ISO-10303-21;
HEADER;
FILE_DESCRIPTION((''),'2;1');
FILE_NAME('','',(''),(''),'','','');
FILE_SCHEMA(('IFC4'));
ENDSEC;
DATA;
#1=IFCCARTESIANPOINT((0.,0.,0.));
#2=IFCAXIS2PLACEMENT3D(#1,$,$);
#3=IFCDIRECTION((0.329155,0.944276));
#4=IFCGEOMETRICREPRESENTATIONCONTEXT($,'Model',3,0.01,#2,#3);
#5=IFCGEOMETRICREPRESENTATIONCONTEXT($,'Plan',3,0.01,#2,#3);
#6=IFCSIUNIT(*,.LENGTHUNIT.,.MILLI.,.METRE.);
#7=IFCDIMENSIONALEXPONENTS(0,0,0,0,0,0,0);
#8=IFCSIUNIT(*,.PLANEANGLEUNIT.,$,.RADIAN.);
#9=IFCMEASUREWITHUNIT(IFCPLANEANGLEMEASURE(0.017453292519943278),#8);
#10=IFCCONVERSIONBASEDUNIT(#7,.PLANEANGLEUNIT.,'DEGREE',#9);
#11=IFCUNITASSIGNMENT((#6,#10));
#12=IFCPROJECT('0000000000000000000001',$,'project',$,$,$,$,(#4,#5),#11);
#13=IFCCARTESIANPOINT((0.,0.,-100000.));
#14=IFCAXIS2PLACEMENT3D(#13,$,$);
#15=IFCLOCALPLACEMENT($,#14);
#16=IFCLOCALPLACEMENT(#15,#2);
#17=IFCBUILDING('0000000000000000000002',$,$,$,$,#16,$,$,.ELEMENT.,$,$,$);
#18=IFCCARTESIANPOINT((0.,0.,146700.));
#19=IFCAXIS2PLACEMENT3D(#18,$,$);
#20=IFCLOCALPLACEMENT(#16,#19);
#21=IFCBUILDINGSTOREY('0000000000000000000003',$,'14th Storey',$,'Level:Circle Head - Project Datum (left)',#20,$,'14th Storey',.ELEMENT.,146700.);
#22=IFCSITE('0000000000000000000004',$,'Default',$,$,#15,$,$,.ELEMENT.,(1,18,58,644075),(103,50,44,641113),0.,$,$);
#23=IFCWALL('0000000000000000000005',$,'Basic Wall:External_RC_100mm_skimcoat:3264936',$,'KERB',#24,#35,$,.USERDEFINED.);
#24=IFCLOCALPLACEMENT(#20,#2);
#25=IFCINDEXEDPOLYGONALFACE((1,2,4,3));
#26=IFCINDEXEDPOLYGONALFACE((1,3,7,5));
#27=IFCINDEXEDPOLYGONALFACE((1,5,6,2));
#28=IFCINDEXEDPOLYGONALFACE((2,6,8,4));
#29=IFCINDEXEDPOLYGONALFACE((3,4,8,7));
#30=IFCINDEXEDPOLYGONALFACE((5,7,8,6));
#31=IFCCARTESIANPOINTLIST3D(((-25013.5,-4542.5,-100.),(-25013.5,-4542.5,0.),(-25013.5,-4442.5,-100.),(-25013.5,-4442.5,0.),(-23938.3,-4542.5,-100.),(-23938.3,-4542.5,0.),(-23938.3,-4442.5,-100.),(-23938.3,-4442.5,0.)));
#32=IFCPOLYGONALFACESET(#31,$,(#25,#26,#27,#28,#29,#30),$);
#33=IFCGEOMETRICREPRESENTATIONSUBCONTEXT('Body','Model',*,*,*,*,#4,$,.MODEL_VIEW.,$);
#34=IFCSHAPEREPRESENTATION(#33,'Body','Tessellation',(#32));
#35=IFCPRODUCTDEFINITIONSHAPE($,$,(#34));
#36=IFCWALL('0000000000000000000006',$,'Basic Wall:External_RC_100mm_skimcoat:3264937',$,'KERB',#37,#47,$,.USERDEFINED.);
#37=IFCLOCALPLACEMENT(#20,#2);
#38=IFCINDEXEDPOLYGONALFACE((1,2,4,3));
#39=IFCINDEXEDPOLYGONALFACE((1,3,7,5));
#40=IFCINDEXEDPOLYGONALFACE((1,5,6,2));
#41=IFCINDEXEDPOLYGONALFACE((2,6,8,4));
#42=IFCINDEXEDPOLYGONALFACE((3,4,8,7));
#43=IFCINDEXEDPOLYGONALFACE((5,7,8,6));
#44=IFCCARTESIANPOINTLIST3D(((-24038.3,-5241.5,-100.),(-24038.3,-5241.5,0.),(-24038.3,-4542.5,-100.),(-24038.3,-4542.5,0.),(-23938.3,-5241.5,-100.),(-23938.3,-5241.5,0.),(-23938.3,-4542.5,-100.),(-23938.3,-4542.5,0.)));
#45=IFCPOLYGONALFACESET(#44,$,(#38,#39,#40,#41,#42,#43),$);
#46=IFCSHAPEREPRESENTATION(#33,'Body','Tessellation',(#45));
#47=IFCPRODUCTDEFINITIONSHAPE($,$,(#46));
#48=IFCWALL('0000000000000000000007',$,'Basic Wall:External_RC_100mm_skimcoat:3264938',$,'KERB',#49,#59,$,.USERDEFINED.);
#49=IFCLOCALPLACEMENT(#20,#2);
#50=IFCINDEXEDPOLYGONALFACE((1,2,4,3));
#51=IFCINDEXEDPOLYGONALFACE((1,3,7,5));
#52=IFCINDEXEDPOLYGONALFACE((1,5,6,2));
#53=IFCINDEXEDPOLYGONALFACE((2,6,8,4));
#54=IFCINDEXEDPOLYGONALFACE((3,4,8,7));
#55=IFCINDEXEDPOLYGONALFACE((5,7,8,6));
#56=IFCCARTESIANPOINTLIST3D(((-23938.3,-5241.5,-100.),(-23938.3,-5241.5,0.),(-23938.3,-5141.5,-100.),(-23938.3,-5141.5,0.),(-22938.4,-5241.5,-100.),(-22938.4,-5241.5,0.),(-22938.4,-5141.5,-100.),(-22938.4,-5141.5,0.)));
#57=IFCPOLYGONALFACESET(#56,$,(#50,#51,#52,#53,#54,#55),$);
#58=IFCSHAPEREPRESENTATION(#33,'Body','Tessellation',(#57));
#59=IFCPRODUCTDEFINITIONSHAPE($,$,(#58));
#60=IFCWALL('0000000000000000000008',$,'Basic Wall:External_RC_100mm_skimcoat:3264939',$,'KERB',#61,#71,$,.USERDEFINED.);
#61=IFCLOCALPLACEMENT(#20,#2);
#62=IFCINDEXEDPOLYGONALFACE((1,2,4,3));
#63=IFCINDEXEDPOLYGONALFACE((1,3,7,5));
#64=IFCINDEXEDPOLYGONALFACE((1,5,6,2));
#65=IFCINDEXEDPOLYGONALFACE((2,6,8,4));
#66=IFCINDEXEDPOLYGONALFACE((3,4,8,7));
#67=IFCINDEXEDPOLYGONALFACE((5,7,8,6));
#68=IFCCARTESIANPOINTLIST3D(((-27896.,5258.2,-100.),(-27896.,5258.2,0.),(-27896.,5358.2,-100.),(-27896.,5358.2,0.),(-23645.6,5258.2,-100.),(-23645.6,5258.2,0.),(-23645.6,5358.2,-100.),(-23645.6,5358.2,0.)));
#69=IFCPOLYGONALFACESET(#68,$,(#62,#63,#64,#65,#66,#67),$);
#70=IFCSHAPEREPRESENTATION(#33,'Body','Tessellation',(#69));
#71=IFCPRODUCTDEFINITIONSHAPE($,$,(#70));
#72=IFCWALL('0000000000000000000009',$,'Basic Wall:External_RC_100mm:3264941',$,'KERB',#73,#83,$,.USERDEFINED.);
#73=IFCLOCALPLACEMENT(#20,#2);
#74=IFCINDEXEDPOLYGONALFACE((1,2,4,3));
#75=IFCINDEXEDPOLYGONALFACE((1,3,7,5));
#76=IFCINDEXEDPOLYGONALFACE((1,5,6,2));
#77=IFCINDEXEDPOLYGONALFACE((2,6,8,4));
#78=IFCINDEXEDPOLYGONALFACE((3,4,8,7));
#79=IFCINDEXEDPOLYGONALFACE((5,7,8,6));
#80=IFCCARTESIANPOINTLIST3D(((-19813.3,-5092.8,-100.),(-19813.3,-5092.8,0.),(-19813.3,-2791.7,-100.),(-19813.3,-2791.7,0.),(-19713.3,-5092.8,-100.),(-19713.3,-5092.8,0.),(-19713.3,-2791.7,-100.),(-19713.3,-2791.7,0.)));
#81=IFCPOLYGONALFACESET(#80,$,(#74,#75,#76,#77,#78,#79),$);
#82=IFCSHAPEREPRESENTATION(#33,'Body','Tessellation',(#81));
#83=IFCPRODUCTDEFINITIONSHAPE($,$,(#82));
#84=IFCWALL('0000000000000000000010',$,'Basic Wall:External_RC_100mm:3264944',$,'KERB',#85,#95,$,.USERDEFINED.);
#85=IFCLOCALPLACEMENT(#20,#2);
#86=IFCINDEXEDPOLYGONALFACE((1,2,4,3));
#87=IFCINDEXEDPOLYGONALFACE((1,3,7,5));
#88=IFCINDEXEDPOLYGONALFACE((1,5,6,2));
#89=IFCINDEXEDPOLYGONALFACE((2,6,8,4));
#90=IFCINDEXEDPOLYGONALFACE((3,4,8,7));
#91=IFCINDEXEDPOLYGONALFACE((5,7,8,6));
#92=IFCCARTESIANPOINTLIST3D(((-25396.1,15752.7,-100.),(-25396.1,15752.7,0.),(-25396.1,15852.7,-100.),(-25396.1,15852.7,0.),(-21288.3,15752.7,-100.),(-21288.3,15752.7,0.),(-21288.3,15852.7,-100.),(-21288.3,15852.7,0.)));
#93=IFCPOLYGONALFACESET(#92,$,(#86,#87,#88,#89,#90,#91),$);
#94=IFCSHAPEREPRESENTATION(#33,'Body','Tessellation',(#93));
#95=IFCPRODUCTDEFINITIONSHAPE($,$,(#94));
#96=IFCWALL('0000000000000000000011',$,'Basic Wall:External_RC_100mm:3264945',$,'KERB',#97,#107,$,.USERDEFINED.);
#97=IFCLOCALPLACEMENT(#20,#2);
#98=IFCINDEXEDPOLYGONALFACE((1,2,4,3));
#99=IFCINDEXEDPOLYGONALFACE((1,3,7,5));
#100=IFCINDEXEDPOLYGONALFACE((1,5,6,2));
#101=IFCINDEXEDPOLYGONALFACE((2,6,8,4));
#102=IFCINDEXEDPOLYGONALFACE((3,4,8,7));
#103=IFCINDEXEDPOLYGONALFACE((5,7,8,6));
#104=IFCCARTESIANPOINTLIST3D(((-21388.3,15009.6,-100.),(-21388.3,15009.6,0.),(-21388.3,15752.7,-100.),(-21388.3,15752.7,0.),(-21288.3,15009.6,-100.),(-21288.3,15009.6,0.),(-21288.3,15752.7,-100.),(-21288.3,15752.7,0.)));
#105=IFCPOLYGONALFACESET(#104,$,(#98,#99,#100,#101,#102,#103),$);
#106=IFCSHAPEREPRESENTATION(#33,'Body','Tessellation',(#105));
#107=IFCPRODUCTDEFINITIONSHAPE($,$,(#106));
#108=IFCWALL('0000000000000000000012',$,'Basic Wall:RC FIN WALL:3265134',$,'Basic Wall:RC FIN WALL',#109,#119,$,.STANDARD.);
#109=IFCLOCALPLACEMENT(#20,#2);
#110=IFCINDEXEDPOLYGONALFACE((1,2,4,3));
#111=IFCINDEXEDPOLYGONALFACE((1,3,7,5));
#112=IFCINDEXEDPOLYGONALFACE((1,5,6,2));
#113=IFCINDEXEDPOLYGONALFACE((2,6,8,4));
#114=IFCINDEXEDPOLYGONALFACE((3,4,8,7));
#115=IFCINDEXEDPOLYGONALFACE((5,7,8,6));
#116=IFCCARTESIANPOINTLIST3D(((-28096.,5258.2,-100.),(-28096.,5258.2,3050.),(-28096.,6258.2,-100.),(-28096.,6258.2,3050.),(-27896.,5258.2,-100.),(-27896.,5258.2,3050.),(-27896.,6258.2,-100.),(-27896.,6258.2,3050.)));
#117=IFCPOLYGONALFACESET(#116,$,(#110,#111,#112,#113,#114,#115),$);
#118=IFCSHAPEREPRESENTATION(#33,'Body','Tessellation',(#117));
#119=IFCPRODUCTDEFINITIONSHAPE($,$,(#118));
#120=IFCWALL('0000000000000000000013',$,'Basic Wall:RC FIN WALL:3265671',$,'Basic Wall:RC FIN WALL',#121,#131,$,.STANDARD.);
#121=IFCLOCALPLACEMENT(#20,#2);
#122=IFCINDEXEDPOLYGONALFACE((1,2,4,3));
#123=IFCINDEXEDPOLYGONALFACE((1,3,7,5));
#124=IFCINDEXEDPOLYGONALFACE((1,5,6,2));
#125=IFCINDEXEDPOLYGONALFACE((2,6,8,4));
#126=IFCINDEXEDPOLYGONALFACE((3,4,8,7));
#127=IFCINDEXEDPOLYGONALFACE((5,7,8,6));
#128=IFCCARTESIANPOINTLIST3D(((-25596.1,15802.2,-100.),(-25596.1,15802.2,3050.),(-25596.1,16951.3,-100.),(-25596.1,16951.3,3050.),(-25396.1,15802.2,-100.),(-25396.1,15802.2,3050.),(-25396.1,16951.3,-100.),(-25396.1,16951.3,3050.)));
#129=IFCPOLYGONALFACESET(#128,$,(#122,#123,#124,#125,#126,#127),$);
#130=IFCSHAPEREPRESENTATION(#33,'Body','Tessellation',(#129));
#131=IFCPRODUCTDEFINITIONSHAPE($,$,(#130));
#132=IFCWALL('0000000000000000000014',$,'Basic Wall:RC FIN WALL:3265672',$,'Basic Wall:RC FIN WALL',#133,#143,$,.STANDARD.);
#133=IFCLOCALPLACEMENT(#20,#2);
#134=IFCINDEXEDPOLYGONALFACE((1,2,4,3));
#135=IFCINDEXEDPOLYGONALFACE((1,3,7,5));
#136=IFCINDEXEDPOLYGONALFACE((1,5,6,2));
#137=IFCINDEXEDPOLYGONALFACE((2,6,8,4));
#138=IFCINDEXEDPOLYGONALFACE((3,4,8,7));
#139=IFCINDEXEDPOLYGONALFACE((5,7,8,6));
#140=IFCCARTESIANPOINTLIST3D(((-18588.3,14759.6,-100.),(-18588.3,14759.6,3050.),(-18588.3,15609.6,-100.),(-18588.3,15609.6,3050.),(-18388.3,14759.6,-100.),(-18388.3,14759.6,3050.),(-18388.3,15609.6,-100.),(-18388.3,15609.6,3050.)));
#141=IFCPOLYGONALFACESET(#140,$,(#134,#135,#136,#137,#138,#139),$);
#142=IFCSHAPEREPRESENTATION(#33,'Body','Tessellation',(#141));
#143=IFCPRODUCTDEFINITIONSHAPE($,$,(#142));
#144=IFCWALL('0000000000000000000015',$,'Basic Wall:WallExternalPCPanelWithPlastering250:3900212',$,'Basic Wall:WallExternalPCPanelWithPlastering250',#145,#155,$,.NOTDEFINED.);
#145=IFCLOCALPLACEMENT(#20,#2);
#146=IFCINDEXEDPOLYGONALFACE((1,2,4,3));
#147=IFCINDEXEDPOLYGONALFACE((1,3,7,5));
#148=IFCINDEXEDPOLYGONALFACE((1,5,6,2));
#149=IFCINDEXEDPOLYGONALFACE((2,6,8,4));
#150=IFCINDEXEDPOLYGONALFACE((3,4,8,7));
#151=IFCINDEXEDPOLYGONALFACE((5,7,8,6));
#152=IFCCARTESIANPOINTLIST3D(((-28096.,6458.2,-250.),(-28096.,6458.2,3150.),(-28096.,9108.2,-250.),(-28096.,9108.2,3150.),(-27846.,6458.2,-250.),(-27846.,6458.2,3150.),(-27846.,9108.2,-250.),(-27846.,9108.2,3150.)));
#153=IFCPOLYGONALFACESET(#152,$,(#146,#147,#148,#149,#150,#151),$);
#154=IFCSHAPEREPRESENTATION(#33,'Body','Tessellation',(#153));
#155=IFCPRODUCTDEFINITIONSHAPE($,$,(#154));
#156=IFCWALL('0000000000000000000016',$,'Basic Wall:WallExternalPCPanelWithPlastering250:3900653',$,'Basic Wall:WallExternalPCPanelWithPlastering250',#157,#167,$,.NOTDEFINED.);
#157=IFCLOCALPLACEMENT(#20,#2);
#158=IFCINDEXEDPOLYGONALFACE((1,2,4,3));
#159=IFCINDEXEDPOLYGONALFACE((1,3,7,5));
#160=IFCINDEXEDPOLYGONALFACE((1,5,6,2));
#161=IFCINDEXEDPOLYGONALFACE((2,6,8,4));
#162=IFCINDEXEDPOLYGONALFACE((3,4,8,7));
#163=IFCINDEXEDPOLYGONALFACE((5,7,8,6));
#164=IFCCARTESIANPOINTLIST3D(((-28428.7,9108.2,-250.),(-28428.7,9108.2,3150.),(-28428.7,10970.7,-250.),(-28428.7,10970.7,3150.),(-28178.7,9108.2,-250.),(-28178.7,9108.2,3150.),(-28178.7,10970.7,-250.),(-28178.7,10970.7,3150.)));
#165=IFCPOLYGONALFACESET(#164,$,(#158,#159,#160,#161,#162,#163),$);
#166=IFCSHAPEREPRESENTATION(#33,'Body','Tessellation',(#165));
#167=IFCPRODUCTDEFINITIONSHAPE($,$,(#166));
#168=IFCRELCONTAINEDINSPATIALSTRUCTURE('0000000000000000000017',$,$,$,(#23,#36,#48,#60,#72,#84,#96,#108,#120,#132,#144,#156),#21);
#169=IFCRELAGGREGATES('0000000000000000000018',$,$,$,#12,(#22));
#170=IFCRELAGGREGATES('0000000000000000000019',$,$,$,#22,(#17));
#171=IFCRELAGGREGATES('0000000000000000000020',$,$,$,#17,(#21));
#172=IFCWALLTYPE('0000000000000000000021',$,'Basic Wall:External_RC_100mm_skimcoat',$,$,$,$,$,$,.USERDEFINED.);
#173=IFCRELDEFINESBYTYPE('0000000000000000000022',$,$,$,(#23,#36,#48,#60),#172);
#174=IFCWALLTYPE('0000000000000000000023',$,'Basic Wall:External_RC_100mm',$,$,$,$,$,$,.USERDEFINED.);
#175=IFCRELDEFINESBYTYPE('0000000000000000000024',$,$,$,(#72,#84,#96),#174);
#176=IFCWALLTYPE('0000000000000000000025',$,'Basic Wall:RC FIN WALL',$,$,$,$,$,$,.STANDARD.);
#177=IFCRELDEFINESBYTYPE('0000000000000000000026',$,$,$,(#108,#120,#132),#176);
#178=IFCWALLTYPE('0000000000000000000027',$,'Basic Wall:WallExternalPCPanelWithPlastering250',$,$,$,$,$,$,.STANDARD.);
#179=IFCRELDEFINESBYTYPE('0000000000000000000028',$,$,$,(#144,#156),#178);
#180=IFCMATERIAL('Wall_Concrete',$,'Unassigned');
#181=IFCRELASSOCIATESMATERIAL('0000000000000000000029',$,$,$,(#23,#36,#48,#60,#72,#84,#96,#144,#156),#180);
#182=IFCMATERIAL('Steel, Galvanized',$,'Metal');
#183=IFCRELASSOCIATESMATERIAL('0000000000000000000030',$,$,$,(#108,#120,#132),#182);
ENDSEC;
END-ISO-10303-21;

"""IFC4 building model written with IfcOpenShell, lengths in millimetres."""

from ifc_helpers import new_model, entity, si_unit, converted_unit, direction, frame, origin, place, context, subcontext, project, spatial, indexed_curve, outline, extrude, material, type_object, element, save


model = new_model("IFC4")

# Units and contexts
model_context = context("Model", 3, precision=0.01, world=origin(), true_north=direction((0.329155, 0.944276)))
plan_context = context("Plan", 3, precision=0.01, world=origin(), true_north=direction((0.329155, 0.944276)))
body_context = subcontext(model_context, "Body", "Model", "MODEL_VIEW")
ifc_project = project(units=[si_unit("LENGTHUNIT", "METRE", prefix="MILLI"), converted_unit("PLANEANGLEUNIT", "DEGREE", entity("IfcPlaneAngleMeasure", 0.017453292519943278), si_unit("PLANEANGLEUNIT", "RADIAN"), dimensions=[0, 0, 0, 0, 0, 0, 0])], contexts=[model_context, plan_context])

# Site, building, storey
site_placement = place(None, frame((0.0, 0.0, -100000.0)))
site = spatial("IfcSite", under=ifc_project, at=site_placement, Name="Default", CompositionType="ELEMENT", RefLatitude=(1, 18, 58, 644075), RefLongitude=(103, 50, 44, 641113), RefElevation=0.0)
building_placement = place(site_placement, origin())
building = spatial("IfcBuilding", under=site, at=building_placement, CompositionType="ELEMENT")
storey_placement = place(building_placement, frame((0.0, 0.0, 146700.0)))
storey = spatial("IfcBuildingStorey", under=building, at=storey_placement, Name="14th Storey", ObjectType="Level:Circle Head - Project Datum (left)", LongName="14th Storey", CompositionType="ELEMENT", Elevation=146700.0)

# Walls
ifc_material_1 = material(Name="Wall_Concrete", Category="Unassigned")
wall_type_1 = type_object("IfcWallType", Name="Basic Wall:External_RC_100mm_skimcoat", PredefinedType="USERDEFINED")
wall_1_placement = place(storey_placement, frame((-25013.5, -4492.5, -100.0)))
element("IfcWall", 1, at=wall_1_placement, inside=storey, type_object=wall_type_1, material=ifc_material_1, Name="Basic Wall:External_RC_100mm_skimcoat:3264936", ObjectType="KERB", PredefinedType="USERDEFINED", context=body_context, shape_type="SweptSolid", body=[
    extrude(outline(indexed_curve([(1075.2, 50.0), (0.0, 50.0), (0.0, -50.0), (1075.2, -50.0), (1075.2, 50.0)], self_intersect=False)), origin(), (0.0, 0.0, 1.0), 100.0),
])
wall_2_placement = place(storey_placement, frame((-23988.3, -4542.5, -100.0), z_axis=(0.0, 0.0, 1.0), x_axis=(0.0, -1.0, 0.0)))
element("IfcWall", 2, at=wall_2_placement, inside=storey, type_object=wall_type_1, material=ifc_material_1, Name="Basic Wall:External_RC_100mm_skimcoat:3264937", ObjectType="KERB", PredefinedType="USERDEFINED", context=body_context, shape_type="SweptSolid", body=[
    extrude(outline(indexed_curve([(699.0, 50.0), (0.0, 50.0), (0.0, -50.0), (699.0, -50.0), (699.0, 50.0)], self_intersect=False)), origin(), (0.0, 0.0, 1.0), 100.0),
])
wall_3_placement = place(storey_placement, frame((-23938.3, -5191.5, -100.0)))
element("IfcWall", 3, at=wall_3_placement, inside=storey, type_object=wall_type_1, material=ifc_material_1, Name="Basic Wall:External_RC_100mm_skimcoat:3264938", ObjectType="KERB", PredefinedType="USERDEFINED", context=body_context, shape_type="SweptSolid", body=[
    extrude(outline(indexed_curve([(1000.0, 50.0), (0.0, 50.0), (0.0, -50.0), (1000.0, -50.0), (1000.0, 50.0)], self_intersect=False)), origin(), (0.0, 0.0, 1.0), 100.0),
])
wall_4_placement = place(storey_placement, frame((-27896.0, 5308.2, -100.0)))
element("IfcWall", 4, at=wall_4_placement, inside=storey, type_object=wall_type_1, material=ifc_material_1, Name="Basic Wall:External_RC_100mm_skimcoat:3264939", ObjectType="KERB", PredefinedType="USERDEFINED", context=body_context, shape_type="SweptSolid", body=[
    extrude(outline(indexed_curve([(4250.4, 50.0), (0.0, 50.0), (0.0, -50.0), (4250.4, -50.0), (4250.4, 50.0)], self_intersect=False)), origin(), (0.0, 0.0, 1.0), 100.0),
])
wall_type_2 = type_object("IfcWallType", Name="Basic Wall:External_RC_100mm", PredefinedType="USERDEFINED")
wall_5_placement = place(storey_placement, frame((-19763.3, -5092.8, -100.0), z_axis=(0.0, 0.0, 1.0), x_axis=(0.0, 1.0, 0.0)))
element("IfcWall", 5, at=wall_5_placement, inside=storey, type_object=wall_type_2, material=ifc_material_1, Name="Basic Wall:External_RC_100mm:3264941", ObjectType="KERB", PredefinedType="USERDEFINED", context=body_context, shape_type="SweptSolid", body=[
    extrude(outline(indexed_curve([(2301.0, 50.0), (0.0, 50.0), (0.0, -50.0), (2301.0, -50.0), (2301.0, 50.0)], self_intersect=False)), origin(), (0.0, 0.0, 1.0), 100.0),
])
wall_6_placement = place(storey_placement, frame((-25396.1, 15802.7, -100.0)))
element("IfcWall", 6, at=wall_6_placement, inside=storey, type_object=wall_type_2, material=ifc_material_1, Name="Basic Wall:External_RC_100mm:3264944", ObjectType="KERB", PredefinedType="USERDEFINED", context=body_context, shape_type="SweptSolid", body=[
    extrude(outline(indexed_curve([(4107.8, 50.0), (0.0, 50.0), (0.0, -50.0), (4107.8, -50.0), (4107.8, 50.0)], self_intersect=False)), origin(), (0.0, 0.0, 1.0), 100.0),
])
wall_7_placement = place(storey_placement, frame((-21338.3, 15752.7, -100.0), z_axis=(0.0, 0.0, 1.0), x_axis=(0.0, -1.0, 0.0)))
element("IfcWall", 7, at=wall_7_placement, inside=storey, type_object=wall_type_2, material=ifc_material_1, Name="Basic Wall:External_RC_100mm:3264945", ObjectType="KERB", PredefinedType="USERDEFINED", context=body_context, shape_type="SweptSolid", body=[
    extrude(outline(indexed_curve([(743.1, 50.0), (0.0, 50.0), (0.0, -50.0), (743.1, -50.0), (743.1, 50.0)], self_intersect=False)), origin(), (0.0, 0.0, 1.0), 100.0),
])
ifc_material_2 = material(Name="Steel, Galvanized", Category="Metal")
wall_type_3 = type_object("IfcWallType", Name="Basic Wall:RC FIN WALL", PredefinedType="STANDARD")
wall_8_placement = place(storey_placement, frame((-27996.0, 6258.2, -100.0), z_axis=(0.0, 0.0, 1.0), x_axis=(0.0, -1.0, 0.0)))
element("IfcWall", 8, at=wall_8_placement, inside=storey, type_object=wall_type_3, material=ifc_material_2, Name="Basic Wall:RC FIN WALL:3265134", ObjectType="Basic Wall:RC FIN WALL", PredefinedType="STANDARD", context=body_context, shape_type="SweptSolid", body=[
    extrude(outline(indexed_curve([(1000.0, 100.0), (0.0, 100.0), (0.0, -100.0), (1000.0, -100.0), (1000.0, 100.0)], self_intersect=False)), origin(), (0.0, 0.0, 1.0), 3150.0),
])
wall_9_placement = place(storey_placement, frame((-25496.1, 15802.2, -100.0), z_axis=(0.0, 0.0, 1.0), x_axis=(0.0, 1.0, 0.0)))
element("IfcWall", 9, at=wall_9_placement, inside=storey, type_object=wall_type_3, material=ifc_material_2, Name="Basic Wall:RC FIN WALL:3265671", ObjectType="Basic Wall:RC FIN WALL", PredefinedType="STANDARD", context=body_context, shape_type="SweptSolid", body=[
    extrude(outline(indexed_curve([(1149.1, 100.0), (0.0, 100.0), (0.0, -100.0), (1149.1, -100.0), (1149.1, 100.0)], self_intersect=False)), origin(), (0.0, 0.0, 1.0), 3150.0),
])
wall_10_placement = place(storey_placement, frame((-18488.3, 14759.6, -100.0), z_axis=(0.0, 0.0, 1.0), x_axis=(0.0, 1.0, 0.0)))
element("IfcWall", 10, at=wall_10_placement, inside=storey, type_object=wall_type_3, material=ifc_material_2, Name="Basic Wall:RC FIN WALL:3265672", ObjectType="Basic Wall:RC FIN WALL", PredefinedType="STANDARD", context=body_context, shape_type="SweptSolid", body=[
    extrude(outline(indexed_curve([(850.0, 100.0), (0.0, 100.0), (0.0, -100.0), (850.0, -100.0), (850.0, 100.0)], self_intersect=False)), origin(), (0.0, 0.0, 1.0), 3150.0),
])
wall_type_4 = type_object("IfcWallType", Name="Basic Wall:WallExternalPCPanelWithPlastering250", PredefinedType="STANDARD")
wall_11_placement = place(storey_placement, frame((-27971.0, 9108.2, -250.0), z_axis=(0.0, 0.0, 1.0), x_axis=(0.0, -1.0, 0.0)))
element("IfcWall", 11, at=wall_11_placement, inside=storey, type_object=wall_type_4, material=ifc_material_1, Name="Basic Wall:WallExternalPCPanelWithPlastering250:3900212", ObjectType="Basic Wall:WallExternalPCPanelWithPlastering250", PredefinedType="NOTDEFINED", context=body_context, shape_type="SweptSolid", body=[
    extrude(outline(indexed_curve([(2650.0, 125.0), (0.0, 125.0), (0.0, -125.0), (2650.0, -125.0), (2650.0, 125.0)], self_intersect=False)), origin(), (0.0, 0.0, 1.0), 3400.0),
])
wall_12_placement = place(storey_placement, frame((-28303.7, 9108.2, -250.0), z_axis=(0.0, 0.0, 1.0), x_axis=(0.0, 1.0, 0.0)))
element("IfcWall", 12, at=wall_12_placement, inside=storey, type_object=wall_type_4, material=ifc_material_1, Name="Basic Wall:WallExternalPCPanelWithPlastering250:3900653", ObjectType="Basic Wall:WallExternalPCPanelWithPlastering250", PredefinedType="NOTDEFINED", context=body_context, shape_type="SweptSolid", body=[
    extrude(outline(indexed_curve([(1862.5, 125.0), (0.0, 125.0), (0.0, -125.0), (1862.5, -125.0), (1862.5, 125.0)], self_intersect=False)), origin(), (0.0, 0.0, 1.0), 3400.0),
])

save(model, "model.ifc")
